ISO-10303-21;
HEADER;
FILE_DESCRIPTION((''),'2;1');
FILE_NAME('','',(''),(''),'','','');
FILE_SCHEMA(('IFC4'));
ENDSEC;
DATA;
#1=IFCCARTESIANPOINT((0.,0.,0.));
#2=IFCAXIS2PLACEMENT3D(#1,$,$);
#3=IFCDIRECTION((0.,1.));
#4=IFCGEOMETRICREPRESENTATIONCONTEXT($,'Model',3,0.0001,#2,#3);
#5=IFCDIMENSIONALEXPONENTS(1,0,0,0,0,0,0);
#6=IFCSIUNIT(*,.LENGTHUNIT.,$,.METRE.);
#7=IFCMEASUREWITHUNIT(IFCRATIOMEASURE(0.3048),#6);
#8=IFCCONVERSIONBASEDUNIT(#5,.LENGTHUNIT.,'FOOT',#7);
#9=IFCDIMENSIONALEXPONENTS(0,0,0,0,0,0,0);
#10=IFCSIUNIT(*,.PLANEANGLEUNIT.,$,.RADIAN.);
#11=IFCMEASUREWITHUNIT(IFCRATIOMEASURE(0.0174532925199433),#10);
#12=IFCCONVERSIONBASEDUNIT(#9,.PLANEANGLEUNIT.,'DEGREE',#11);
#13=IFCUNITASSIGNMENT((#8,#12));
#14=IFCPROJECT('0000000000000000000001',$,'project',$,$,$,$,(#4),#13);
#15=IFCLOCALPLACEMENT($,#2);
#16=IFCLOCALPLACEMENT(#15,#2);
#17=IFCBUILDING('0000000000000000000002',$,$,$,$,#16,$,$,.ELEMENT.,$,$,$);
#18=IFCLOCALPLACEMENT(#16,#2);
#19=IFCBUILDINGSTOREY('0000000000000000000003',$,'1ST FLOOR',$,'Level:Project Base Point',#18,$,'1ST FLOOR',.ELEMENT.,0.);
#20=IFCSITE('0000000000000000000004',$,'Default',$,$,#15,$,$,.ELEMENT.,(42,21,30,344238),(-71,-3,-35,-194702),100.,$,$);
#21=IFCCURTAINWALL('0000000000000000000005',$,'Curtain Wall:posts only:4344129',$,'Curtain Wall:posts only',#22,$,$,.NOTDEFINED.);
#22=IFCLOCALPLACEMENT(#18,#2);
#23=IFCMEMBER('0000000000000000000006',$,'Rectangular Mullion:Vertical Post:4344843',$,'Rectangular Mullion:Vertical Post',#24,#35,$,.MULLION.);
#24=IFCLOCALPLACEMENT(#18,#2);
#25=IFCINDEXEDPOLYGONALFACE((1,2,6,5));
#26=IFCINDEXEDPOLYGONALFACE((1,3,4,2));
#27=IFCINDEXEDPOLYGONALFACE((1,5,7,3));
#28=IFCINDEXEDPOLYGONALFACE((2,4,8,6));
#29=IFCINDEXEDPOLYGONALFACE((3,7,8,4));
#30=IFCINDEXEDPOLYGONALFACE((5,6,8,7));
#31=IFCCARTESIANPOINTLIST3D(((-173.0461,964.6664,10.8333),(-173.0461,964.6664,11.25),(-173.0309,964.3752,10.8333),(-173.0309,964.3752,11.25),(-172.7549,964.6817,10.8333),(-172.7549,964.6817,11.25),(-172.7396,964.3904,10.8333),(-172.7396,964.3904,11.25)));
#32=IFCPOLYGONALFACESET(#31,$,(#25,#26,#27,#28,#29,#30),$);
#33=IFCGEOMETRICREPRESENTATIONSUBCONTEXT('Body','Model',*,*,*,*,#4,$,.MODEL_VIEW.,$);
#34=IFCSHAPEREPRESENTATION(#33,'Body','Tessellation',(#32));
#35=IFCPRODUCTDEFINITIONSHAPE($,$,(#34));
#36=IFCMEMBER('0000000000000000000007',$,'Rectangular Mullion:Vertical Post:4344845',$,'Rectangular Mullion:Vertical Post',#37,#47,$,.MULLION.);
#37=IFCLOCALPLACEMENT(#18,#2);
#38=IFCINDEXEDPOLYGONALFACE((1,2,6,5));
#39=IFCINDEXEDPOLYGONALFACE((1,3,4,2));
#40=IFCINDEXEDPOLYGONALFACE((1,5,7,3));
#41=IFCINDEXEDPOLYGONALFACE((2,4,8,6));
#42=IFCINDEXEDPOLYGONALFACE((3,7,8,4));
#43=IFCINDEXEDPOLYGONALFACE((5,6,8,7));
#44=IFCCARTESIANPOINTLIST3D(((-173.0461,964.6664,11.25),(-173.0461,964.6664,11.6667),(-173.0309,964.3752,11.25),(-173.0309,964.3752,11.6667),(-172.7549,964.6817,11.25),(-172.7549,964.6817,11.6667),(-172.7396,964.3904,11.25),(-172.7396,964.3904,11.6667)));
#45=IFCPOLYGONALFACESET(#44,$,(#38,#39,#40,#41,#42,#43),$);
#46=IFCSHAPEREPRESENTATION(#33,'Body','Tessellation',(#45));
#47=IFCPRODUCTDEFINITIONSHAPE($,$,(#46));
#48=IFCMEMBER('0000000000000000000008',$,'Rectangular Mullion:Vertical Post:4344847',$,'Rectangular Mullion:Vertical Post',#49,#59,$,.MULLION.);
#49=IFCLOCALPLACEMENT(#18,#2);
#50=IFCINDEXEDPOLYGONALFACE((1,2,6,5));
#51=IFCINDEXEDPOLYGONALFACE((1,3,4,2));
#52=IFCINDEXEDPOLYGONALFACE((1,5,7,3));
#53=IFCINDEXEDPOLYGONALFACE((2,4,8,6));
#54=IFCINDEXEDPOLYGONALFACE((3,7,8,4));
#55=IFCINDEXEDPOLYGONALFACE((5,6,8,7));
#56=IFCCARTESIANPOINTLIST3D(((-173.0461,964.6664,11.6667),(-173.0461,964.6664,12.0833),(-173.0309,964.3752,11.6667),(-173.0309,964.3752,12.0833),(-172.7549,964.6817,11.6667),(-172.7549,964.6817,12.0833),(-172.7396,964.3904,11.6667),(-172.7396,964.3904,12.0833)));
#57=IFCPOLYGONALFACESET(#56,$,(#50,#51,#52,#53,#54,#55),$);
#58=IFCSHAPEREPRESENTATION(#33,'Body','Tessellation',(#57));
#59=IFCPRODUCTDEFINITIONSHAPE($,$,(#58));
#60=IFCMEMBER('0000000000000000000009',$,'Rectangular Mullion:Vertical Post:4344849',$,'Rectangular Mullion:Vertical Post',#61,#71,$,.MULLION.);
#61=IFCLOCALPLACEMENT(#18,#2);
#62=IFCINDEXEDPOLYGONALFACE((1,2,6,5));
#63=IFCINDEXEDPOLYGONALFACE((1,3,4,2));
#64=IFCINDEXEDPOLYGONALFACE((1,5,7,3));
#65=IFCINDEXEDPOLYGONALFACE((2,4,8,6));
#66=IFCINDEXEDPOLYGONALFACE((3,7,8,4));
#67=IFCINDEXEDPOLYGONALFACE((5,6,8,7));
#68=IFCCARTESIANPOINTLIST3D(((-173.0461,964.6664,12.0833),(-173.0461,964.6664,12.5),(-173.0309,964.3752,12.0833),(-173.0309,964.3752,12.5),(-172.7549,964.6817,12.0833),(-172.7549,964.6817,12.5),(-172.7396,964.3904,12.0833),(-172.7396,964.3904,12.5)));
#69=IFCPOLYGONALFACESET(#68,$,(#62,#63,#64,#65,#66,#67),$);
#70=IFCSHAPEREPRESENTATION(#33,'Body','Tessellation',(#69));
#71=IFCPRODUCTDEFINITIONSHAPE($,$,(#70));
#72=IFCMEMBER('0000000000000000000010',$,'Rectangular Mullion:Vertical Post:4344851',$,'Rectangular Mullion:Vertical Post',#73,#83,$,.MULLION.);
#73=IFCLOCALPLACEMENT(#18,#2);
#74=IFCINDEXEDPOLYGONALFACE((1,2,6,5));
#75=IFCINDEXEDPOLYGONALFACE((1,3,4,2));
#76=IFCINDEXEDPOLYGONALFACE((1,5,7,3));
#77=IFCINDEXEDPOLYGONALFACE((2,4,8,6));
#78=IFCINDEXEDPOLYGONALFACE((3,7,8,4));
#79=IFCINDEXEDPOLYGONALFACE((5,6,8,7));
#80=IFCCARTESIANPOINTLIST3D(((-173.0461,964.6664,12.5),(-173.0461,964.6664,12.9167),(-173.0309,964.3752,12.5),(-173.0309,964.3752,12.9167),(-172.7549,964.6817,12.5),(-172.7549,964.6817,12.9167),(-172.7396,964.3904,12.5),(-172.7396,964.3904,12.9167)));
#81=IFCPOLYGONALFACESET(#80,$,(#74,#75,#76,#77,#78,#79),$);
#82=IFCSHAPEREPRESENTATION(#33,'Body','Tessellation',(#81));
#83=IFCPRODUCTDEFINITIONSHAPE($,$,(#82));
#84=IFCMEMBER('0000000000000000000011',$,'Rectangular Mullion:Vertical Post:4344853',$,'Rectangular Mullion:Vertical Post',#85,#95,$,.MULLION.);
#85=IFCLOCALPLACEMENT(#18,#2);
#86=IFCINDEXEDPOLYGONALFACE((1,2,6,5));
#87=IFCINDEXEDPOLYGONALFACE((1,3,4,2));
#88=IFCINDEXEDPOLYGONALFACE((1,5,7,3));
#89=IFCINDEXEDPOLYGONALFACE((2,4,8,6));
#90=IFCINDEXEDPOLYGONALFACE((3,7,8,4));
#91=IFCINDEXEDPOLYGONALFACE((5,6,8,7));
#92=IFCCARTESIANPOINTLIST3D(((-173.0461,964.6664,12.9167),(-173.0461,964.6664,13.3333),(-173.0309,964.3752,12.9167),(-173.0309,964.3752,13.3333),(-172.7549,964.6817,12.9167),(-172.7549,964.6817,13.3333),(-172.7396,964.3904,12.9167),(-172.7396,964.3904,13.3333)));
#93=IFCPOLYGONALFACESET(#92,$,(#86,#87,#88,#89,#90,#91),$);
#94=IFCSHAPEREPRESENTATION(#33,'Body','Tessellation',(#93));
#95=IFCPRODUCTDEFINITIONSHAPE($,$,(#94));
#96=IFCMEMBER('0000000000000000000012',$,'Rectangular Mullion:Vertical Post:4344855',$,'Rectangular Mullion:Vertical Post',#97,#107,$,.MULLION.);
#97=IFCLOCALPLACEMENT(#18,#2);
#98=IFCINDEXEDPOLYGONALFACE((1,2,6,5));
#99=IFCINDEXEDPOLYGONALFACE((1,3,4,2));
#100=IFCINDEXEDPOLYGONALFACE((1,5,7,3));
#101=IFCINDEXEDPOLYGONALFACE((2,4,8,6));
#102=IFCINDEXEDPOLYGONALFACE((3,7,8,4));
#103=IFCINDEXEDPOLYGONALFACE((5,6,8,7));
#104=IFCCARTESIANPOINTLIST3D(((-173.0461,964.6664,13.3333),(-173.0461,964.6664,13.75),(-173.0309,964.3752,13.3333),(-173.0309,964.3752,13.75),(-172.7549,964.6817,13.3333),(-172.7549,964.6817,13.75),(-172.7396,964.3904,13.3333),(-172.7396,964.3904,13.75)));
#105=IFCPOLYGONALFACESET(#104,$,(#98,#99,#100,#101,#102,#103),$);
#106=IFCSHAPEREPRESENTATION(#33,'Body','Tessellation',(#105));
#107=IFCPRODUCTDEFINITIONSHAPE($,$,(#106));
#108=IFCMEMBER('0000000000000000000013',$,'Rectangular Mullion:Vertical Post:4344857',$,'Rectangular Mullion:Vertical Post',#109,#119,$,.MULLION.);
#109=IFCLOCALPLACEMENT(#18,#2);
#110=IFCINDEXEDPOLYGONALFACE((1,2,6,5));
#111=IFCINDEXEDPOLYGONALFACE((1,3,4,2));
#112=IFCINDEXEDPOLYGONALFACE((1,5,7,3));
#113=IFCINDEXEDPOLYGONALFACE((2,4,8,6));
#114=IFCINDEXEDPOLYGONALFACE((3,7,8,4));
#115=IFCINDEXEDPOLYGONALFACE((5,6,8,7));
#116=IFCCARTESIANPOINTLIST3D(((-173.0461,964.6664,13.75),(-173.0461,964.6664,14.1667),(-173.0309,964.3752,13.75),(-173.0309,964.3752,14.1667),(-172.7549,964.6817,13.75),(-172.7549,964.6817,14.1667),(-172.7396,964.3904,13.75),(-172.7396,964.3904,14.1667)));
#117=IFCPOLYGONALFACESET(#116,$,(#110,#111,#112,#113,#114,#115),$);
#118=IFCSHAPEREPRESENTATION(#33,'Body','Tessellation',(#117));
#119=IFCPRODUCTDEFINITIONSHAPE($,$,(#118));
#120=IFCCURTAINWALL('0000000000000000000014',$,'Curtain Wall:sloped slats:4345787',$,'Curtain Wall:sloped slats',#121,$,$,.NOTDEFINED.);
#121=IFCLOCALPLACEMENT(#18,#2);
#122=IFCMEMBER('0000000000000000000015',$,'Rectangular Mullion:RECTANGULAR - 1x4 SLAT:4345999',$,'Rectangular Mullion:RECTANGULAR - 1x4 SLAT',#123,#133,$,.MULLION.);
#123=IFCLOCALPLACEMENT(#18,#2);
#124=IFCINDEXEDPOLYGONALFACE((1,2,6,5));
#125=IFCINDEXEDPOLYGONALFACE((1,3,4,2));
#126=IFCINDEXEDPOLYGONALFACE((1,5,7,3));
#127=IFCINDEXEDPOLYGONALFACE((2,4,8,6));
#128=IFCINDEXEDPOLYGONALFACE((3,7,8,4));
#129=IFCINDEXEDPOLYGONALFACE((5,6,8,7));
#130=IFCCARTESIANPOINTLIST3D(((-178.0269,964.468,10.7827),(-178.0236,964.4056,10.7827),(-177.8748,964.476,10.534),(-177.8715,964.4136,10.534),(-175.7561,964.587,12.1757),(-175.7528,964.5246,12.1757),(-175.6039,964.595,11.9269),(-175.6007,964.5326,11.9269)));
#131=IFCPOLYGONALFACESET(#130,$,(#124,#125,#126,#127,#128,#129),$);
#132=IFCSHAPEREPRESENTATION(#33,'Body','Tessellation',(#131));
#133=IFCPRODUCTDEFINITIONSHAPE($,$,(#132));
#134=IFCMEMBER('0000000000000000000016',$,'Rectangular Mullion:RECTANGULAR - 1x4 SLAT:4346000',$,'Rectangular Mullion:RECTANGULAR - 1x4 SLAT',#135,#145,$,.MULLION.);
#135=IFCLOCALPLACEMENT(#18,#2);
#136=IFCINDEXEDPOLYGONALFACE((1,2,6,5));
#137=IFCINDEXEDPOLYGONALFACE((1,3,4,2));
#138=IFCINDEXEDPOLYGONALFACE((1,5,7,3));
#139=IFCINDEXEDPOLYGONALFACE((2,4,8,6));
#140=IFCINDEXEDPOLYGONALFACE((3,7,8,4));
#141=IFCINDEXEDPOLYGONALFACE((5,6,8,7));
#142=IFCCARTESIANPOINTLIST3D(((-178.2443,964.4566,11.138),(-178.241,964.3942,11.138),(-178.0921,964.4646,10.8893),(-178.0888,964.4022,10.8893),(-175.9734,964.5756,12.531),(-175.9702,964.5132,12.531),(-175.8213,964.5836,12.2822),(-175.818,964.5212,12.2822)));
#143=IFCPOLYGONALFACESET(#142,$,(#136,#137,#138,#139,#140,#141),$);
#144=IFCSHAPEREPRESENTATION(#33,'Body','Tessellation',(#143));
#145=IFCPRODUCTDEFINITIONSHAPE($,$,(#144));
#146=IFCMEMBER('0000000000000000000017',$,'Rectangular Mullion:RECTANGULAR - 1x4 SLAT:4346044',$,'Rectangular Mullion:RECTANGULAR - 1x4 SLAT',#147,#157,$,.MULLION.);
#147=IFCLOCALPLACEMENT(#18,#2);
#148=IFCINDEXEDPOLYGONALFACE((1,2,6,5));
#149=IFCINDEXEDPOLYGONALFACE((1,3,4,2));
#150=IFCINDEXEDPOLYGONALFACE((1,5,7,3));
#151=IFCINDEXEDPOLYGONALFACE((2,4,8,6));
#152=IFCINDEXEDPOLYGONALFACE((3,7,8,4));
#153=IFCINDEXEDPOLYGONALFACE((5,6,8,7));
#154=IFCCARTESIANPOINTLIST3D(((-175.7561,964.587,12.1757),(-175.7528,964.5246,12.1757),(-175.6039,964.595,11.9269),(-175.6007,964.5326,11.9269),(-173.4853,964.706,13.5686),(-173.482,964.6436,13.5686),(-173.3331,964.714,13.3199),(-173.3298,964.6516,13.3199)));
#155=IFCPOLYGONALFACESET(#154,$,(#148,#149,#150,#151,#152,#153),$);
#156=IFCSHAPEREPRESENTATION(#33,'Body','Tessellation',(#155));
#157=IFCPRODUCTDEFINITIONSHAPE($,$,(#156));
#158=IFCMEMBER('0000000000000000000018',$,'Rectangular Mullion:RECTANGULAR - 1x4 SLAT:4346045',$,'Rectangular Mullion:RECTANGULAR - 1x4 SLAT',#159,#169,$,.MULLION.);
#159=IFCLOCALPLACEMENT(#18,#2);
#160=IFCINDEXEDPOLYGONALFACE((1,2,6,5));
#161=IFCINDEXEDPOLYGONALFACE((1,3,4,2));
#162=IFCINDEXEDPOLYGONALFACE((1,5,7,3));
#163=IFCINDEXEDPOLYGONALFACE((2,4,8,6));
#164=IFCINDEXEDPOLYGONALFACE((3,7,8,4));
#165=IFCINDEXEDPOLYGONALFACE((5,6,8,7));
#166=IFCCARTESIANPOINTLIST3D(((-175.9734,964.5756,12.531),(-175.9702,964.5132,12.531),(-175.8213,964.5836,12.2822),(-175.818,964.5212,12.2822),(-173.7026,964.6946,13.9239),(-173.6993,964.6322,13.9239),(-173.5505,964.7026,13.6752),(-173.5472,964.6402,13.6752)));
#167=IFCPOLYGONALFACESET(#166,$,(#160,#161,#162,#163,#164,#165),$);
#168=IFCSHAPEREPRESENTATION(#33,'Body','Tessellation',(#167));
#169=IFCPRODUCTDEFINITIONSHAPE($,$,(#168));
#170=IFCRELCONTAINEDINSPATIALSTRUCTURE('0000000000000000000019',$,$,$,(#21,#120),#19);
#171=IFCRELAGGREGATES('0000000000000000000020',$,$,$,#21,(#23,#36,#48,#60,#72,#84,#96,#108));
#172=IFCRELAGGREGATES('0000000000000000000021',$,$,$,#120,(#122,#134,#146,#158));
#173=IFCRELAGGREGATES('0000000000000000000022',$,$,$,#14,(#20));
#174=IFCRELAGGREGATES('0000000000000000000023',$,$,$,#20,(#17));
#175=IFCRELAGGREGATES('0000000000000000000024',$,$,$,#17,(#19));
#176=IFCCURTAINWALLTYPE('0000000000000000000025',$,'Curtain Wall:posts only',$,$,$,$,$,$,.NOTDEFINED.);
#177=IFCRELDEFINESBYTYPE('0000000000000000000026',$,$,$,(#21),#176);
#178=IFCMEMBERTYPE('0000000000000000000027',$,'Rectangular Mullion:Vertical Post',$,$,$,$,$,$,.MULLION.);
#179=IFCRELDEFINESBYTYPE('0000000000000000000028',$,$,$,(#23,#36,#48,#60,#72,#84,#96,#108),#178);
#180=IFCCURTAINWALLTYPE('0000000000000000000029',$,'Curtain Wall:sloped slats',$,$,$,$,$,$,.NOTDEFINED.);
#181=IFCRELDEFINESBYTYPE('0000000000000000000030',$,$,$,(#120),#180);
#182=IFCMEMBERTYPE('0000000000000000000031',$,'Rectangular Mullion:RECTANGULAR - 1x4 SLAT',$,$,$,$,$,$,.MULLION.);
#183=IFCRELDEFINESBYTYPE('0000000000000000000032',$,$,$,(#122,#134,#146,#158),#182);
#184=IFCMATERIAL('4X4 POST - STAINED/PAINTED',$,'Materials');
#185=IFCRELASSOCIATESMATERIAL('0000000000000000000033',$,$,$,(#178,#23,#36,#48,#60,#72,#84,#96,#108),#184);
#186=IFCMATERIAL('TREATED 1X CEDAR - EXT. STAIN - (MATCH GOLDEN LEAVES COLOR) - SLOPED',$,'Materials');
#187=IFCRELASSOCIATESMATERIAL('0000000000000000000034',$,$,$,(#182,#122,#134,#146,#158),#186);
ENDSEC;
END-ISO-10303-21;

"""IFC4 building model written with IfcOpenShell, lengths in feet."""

from ifc_helpers import new_model, entity, si_unit, converted_unit, direction, frame, frame_2d, origin, origin_2d_with_axis, place, context, subcontext, project, spatial, rectangle, extrude, source, transform, mapped, material, material_profile, profile_set, profile_usage, type_object, type_shapes, element, aggregate, save


model = new_model("IFC4")

# Units and contexts
model_context = context("Model", 3, precision=0.0001, world=origin(), true_north=direction((0.0, 1.0)))
body_context = subcontext(model_context, "Body", "Model", "MODEL_VIEW")
ifc_project = project(units=[converted_unit("LENGTHUNIT", "FOOT", entity("IfcRatioMeasure", 0.3048), si_unit("LENGTHUNIT", "METRE"), dimensions=[1, 0, 0, 0, 0, 0, 0]), converted_unit("PLANEANGLEUNIT", "DEGREE", entity("IfcRatioMeasure", 0.0174532925199433), si_unit("PLANEANGLEUNIT", "RADIAN"), dimensions=[0, 0, 0, 0, 0, 0, 0])], contexts=[model_context])

# Site, building, storey
site_placement = place(None, origin())
site = spatial("IfcSite", under=ifc_project, at=site_placement, Name="Default", CompositionType="ELEMENT", RefLatitude=(42, 21, 30, 344238), RefLongitude=(-71, -3, -35, -194702), RefElevation=100.0)
building_placement = place(site_placement, origin())
building = spatial("IfcBuilding", under=site, at=building_placement, CompositionType="ELEMENT")
storey_placement = place(building_placement, origin())
storey = spatial("IfcBuildingStorey", under=building, at=storey_placement, Name="1ST FLOOR", ObjectType="Level:Project Base Point", LongName="1ST FLOOR", CompositionType="ELEMENT", Elevation=0.0)

# Curtain walls, members
curtain_wall_type_1 = type_object("IfcCurtainWallType", Name="Curtain Wall:posts only", PredefinedType="NOTDEFINED")
curtain_wall_1_placement = place(storey_placement, origin())
curtain_wall_1 = element("IfcCurtainWall", 1, at=curtain_wall_1_placement, inside=storey, type_object=curtain_wall_type_1, Name="Curtain Wall:posts only:4344129", ObjectType="Curtain Wall:posts only", PredefinedType="NOTDEFINED")
ifc_material_1 = material(Name="4X4 POST - STAINED/PAINTED", Category="Materials")
ifc_material_profile_1 = material_profile(ifc_material_1, rectangle(XDim=0.2917, YDim=0.2917, at=origin_2d_with_axis()), Name="Vertical Post")
ifc_profile_set_1 = profile_set([ifc_material_profile_1], Name="Vertical Post")
member_type_1 = type_object("IfcMemberType", Name="Rectangular Mullion:Vertical Post", PredefinedType="MULLION", material=ifc_profile_set_1)
shared_shape_1 = source(origin(), body_context, "Body", "SweptSolid", [
    extrude(rectangle(XDim=0.2917, YDim=0.2917, at=origin_2d_with_axis()), frame((0.0, -0.2083, -0.4167), z_axis=(0.0, 0.0, 1.0), x_axis=(0.0, -1.0, 0.0)), (0.0, 0.0, 1.0), 0.4167),
])
type_shapes(member_type_1, [shared_shape_1])
ifc_profile_usage_1 = profile_usage(ifc_profile_set_1)
member_1_placement = place(storey_placement, frame((-172.9038, 964.7365, 10.8333), z_axis=(0.0, 0.0, -1.0), x_axis=(-0.99863, -0.052336, 0.0)))
member_1 = element("IfcMember", 2, at=member_1_placement, type_object=member_type_1, material=ifc_profile_usage_1, Name="Rectangular Mullion:Vertical Post:4344843", ObjectType="Rectangular Mullion:Vertical Post", PredefinedType="MULLION", context=body_context, shape_type="MappedRepresentation", body=[
    mapped(shared_shape_1, transform((0.0, 0.0, 0.0), scale=1.0)),
])
ifc_profile_usage_2 = profile_usage(ifc_profile_set_1)
member_2_placement = place(storey_placement, frame((-172.9038, 964.7365, 11.25), z_axis=(0.0, 0.0, -1.0), x_axis=(-0.99863, -0.052336, 0.0)))
member_2 = element("IfcMember", 3, at=member_2_placement, type_object=member_type_1, material=ifc_profile_usage_2, Name="Rectangular Mullion:Vertical Post:4344845", ObjectType="Rectangular Mullion:Vertical Post", PredefinedType="MULLION", context=body_context, shape_type="MappedRepresentation", body=[
    mapped(shared_shape_1, transform((0.0, 0.0, 0.0), scale=1.0)),
])
ifc_profile_usage_3 = profile_usage(ifc_profile_set_1)
member_3_placement = place(storey_placement, frame((-172.9038, 964.7365, 11.6667), z_axis=(0.0, 0.0, -1.0), x_axis=(-0.99863, -0.052336, 0.0)))
member_3 = element("IfcMember", 4, at=member_3_placement, type_object=member_type_1, material=ifc_profile_usage_3, Name="Rectangular Mullion:Vertical Post:4344847", ObjectType="Rectangular Mullion:Vertical Post", PredefinedType="MULLION", context=body_context, shape_type="MappedRepresentation", body=[
    mapped(shared_shape_1, transform((0.0, 0.0, 0.0), scale=1.0)),
])
ifc_profile_usage_4 = profile_usage(ifc_profile_set_1)
member_4_placement = place(storey_placement, frame((-172.9038, 964.7365, 12.0833), z_axis=(0.0, 0.0, -1.0), x_axis=(-0.99863, -0.052336, 0.0)))
member_4 = element("IfcMember", 5, at=member_4_placement, type_object=member_type_1, material=ifc_profile_usage_4, Name="Rectangular Mullion:Vertical Post:4344849", ObjectType="Rectangular Mullion:Vertical Post", PredefinedType="MULLION", context=body_context, shape_type="MappedRepresentation", body=[
    mapped(shared_shape_1, transform((0.0, 0.0, 0.0), scale=1.0)),
])
ifc_profile_usage_5 = profile_usage(ifc_profile_set_1)
member_5_placement = place(storey_placement, frame((-172.9038, 964.7365, 12.5), z_axis=(0.0, 0.0, -1.0), x_axis=(-0.99863, -0.052336, 0.0)))
member_5 = element("IfcMember", 6, at=member_5_placement, type_object=member_type_1, material=ifc_profile_usage_5, Name="Rectangular Mullion:Vertical Post:4344851", ObjectType="Rectangular Mullion:Vertical Post", PredefinedType="MULLION", context=body_context, shape_type="MappedRepresentation", body=[
    mapped(shared_shape_1, transform((0.0, 0.0, 0.0), scale=1.0)),
])
ifc_profile_usage_6 = profile_usage(ifc_profile_set_1)
member_6_placement = place(storey_placement, frame((-172.9038, 964.7365, 12.9167), z_axis=(0.0, 0.0, -1.0), x_axis=(-0.99863, -0.052336, 0.0)))
member_6 = element("IfcMember", 7, at=member_6_placement, type_object=member_type_1, material=ifc_profile_usage_6, Name="Rectangular Mullion:Vertical Post:4344853", ObjectType="Rectangular Mullion:Vertical Post", PredefinedType="MULLION", context=body_context, shape_type="MappedRepresentation", body=[
    mapped(shared_shape_1, transform((0.0, 0.0, 0.0), scale=1.0)),
])
ifc_profile_usage_7 = profile_usage(ifc_profile_set_1)
member_7_placement = place(storey_placement, frame((-172.9038, 964.7365, 13.3333), z_axis=(0.0, 0.0, -1.0), x_axis=(-0.99863, -0.052336, 0.0)))
member_7 = element("IfcMember", 8, at=member_7_placement, type_object=member_type_1, material=ifc_profile_usage_7, Name="Rectangular Mullion:Vertical Post:4344855", ObjectType="Rectangular Mullion:Vertical Post", PredefinedType="MULLION", context=body_context, shape_type="MappedRepresentation", body=[
    mapped(shared_shape_1, transform((0.0, 0.0, 0.0), scale=1.0)),
])
ifc_profile_usage_8 = profile_usage(ifc_profile_set_1)
member_8_placement = place(storey_placement, frame((-172.9038, 964.7365, 13.75), z_axis=(0.0, 0.0, -1.0), x_axis=(-0.99863, -0.052336, 0.0)))
member_8 = element("IfcMember", 9, at=member_8_placement, type_object=member_type_1, material=ifc_profile_usage_8, Name="Rectangular Mullion:Vertical Post:4344857", ObjectType="Rectangular Mullion:Vertical Post", PredefinedType="MULLION", context=body_context, shape_type="MappedRepresentation", body=[
    mapped(shared_shape_1, transform((0.0, 0.0, 0.0), scale=1.0)),
])
aggregate(curtain_wall_1, [member_1, member_2, member_3, member_4, member_5, member_6, member_7, member_8])
curtain_wall_type_2 = type_object("IfcCurtainWallType", Name="Curtain Wall:sloped slats", PredefinedType="NOTDEFINED")
curtain_wall_2_placement = place(storey_placement, origin())
curtain_wall_2 = element("IfcCurtainWall", 10, at=curtain_wall_2_placement, inside=storey, type_object=curtain_wall_type_2, Name="Curtain Wall:sloped slats:4345787", ObjectType="Curtain Wall:sloped slats", PredefinedType="NOTDEFINED")
ifc_material_2 = material(Name="TREATED 1X CEDAR - EXT. STAIN - (MATCH GOLDEN LEAVES COLOR) - SLOPED", Category="Materials")
ifc_material_profile_2 = material_profile(ifc_material_2, rectangle(XDim=0.0625, YDim=0.2917, at=frame_2d((0.0, 0.0), x_axis=(1.0, 0.0))), Name="RECTANGULAR - 1x4 SLAT")
ifc_profile_set_2 = profile_set([ifc_material_profile_2], Name="RECTANGULAR - 1x4 SLAT")
ifc_profile_usage_9 = profile_usage(ifc_profile_set_2)
member_type_2 = type_object("IfcMemberType", Name="Rectangular Mullion:RECTANGULAR - 1x4 SLAT", PredefinedType="MULLION", material=ifc_profile_set_2)
shared_shape_2 = source(origin(), body_context, "Body", "SweptSolid", [
    extrude(rectangle(XDim=0.0625, YDim=0.2917, at=frame_2d((0.0, 0.0), x_axis=(1.0, 0.0))), frame((0.0, 0.0, -2.6667), z_axis=(0.0, 0.0, 1.0), x_axis=(0.0, -1.0, 0.0)), (0.0, 0.0, 1.0), 2.6667),
])
type_shapes(member_type_2, [shared_shape_2])
member_9_placement = place(storey_placement, frame((-177.9492, 964.4408, 10.6583), z_axis=(-0.851559, -0.044628, -0.522356), x_axis=(-0.52164, -0.027338, 0.852727)))
member_9 = element("IfcMember", 11, at=member_9_placement, type_object=member_type_2, material=ifc_profile_usage_9, Name="Rectangular Mullion:RECTANGULAR - 1x4 SLAT:4345999", ObjectType="Rectangular Mullion:RECTANGULAR - 1x4 SLAT", PredefinedType="MULLION", context=body_context, shape_type="MappedRepresentation", body=[
    mapped(shared_shape_2, transform((0.0, 0.0, 0.0), scale=1.0)),
])
ifc_profile_usage_10 = profile_usage(ifc_profile_set_2)
member_10_placement = place(storey_placement, frame((-178.1666, 964.4294, 11.0136), z_axis=(-0.851559, -0.044628, -0.522356), x_axis=(-0.52164, -0.027338, 0.852727)))
member_10 = element("IfcMember", 12, at=member_10_placement, type_object=member_type_2, material=ifc_profile_usage_10, Name="Rectangular Mullion:RECTANGULAR - 1x4 SLAT:4346000", ObjectType="Rectangular Mullion:RECTANGULAR - 1x4 SLAT", PredefinedType="MULLION", context=body_context, shape_type="MappedRepresentation", body=[
    mapped(shared_shape_2, transform((0.0, 0.0, 0.0), scale=1.0)),
])
ifc_profile_usage_11 = profile_usage(ifc_profile_set_2)
member_11_placement = place(storey_placement, frame((-175.6784, 964.5598, 12.0513), z_axis=(-0.851559, -0.044628, -0.522356), x_axis=(-0.52164, -0.027338, 0.852727)))
member_11 = element("IfcMember", 13, at=member_11_placement, type_object=member_type_2, material=ifc_profile_usage_11, Name="Rectangular Mullion:RECTANGULAR - 1x4 SLAT:4346044", ObjectType="Rectangular Mullion:RECTANGULAR - 1x4 SLAT", PredefinedType="MULLION", context=body_context, shape_type="MappedRepresentation", body=[
    mapped(shared_shape_2, transform((0.0, 0.0, 0.0), scale=1.0)),
])
ifc_profile_usage_12 = profile_usage(ifc_profile_set_2)
member_12_placement = place(storey_placement, frame((-175.8957, 964.5484, 12.4066), z_axis=(-0.851559, -0.044628, -0.522356), x_axis=(-0.52164, -0.027338, 0.852727)))
member_12 = element("IfcMember", 14, at=member_12_placement, type_object=member_type_2, material=ifc_profile_usage_12, Name="Rectangular Mullion:RECTANGULAR - 1x4 SLAT:4346045", ObjectType="Rectangular Mullion:RECTANGULAR - 1x4 SLAT", PredefinedType="MULLION", context=body_context, shape_type="MappedRepresentation", body=[
    mapped(shared_shape_2, transform((0.0, 0.0, 0.0), scale=1.0)),
])
aggregate(curtain_wall_2, [member_9, member_10, member_11, member_12])

save(model, "model.ifc")
